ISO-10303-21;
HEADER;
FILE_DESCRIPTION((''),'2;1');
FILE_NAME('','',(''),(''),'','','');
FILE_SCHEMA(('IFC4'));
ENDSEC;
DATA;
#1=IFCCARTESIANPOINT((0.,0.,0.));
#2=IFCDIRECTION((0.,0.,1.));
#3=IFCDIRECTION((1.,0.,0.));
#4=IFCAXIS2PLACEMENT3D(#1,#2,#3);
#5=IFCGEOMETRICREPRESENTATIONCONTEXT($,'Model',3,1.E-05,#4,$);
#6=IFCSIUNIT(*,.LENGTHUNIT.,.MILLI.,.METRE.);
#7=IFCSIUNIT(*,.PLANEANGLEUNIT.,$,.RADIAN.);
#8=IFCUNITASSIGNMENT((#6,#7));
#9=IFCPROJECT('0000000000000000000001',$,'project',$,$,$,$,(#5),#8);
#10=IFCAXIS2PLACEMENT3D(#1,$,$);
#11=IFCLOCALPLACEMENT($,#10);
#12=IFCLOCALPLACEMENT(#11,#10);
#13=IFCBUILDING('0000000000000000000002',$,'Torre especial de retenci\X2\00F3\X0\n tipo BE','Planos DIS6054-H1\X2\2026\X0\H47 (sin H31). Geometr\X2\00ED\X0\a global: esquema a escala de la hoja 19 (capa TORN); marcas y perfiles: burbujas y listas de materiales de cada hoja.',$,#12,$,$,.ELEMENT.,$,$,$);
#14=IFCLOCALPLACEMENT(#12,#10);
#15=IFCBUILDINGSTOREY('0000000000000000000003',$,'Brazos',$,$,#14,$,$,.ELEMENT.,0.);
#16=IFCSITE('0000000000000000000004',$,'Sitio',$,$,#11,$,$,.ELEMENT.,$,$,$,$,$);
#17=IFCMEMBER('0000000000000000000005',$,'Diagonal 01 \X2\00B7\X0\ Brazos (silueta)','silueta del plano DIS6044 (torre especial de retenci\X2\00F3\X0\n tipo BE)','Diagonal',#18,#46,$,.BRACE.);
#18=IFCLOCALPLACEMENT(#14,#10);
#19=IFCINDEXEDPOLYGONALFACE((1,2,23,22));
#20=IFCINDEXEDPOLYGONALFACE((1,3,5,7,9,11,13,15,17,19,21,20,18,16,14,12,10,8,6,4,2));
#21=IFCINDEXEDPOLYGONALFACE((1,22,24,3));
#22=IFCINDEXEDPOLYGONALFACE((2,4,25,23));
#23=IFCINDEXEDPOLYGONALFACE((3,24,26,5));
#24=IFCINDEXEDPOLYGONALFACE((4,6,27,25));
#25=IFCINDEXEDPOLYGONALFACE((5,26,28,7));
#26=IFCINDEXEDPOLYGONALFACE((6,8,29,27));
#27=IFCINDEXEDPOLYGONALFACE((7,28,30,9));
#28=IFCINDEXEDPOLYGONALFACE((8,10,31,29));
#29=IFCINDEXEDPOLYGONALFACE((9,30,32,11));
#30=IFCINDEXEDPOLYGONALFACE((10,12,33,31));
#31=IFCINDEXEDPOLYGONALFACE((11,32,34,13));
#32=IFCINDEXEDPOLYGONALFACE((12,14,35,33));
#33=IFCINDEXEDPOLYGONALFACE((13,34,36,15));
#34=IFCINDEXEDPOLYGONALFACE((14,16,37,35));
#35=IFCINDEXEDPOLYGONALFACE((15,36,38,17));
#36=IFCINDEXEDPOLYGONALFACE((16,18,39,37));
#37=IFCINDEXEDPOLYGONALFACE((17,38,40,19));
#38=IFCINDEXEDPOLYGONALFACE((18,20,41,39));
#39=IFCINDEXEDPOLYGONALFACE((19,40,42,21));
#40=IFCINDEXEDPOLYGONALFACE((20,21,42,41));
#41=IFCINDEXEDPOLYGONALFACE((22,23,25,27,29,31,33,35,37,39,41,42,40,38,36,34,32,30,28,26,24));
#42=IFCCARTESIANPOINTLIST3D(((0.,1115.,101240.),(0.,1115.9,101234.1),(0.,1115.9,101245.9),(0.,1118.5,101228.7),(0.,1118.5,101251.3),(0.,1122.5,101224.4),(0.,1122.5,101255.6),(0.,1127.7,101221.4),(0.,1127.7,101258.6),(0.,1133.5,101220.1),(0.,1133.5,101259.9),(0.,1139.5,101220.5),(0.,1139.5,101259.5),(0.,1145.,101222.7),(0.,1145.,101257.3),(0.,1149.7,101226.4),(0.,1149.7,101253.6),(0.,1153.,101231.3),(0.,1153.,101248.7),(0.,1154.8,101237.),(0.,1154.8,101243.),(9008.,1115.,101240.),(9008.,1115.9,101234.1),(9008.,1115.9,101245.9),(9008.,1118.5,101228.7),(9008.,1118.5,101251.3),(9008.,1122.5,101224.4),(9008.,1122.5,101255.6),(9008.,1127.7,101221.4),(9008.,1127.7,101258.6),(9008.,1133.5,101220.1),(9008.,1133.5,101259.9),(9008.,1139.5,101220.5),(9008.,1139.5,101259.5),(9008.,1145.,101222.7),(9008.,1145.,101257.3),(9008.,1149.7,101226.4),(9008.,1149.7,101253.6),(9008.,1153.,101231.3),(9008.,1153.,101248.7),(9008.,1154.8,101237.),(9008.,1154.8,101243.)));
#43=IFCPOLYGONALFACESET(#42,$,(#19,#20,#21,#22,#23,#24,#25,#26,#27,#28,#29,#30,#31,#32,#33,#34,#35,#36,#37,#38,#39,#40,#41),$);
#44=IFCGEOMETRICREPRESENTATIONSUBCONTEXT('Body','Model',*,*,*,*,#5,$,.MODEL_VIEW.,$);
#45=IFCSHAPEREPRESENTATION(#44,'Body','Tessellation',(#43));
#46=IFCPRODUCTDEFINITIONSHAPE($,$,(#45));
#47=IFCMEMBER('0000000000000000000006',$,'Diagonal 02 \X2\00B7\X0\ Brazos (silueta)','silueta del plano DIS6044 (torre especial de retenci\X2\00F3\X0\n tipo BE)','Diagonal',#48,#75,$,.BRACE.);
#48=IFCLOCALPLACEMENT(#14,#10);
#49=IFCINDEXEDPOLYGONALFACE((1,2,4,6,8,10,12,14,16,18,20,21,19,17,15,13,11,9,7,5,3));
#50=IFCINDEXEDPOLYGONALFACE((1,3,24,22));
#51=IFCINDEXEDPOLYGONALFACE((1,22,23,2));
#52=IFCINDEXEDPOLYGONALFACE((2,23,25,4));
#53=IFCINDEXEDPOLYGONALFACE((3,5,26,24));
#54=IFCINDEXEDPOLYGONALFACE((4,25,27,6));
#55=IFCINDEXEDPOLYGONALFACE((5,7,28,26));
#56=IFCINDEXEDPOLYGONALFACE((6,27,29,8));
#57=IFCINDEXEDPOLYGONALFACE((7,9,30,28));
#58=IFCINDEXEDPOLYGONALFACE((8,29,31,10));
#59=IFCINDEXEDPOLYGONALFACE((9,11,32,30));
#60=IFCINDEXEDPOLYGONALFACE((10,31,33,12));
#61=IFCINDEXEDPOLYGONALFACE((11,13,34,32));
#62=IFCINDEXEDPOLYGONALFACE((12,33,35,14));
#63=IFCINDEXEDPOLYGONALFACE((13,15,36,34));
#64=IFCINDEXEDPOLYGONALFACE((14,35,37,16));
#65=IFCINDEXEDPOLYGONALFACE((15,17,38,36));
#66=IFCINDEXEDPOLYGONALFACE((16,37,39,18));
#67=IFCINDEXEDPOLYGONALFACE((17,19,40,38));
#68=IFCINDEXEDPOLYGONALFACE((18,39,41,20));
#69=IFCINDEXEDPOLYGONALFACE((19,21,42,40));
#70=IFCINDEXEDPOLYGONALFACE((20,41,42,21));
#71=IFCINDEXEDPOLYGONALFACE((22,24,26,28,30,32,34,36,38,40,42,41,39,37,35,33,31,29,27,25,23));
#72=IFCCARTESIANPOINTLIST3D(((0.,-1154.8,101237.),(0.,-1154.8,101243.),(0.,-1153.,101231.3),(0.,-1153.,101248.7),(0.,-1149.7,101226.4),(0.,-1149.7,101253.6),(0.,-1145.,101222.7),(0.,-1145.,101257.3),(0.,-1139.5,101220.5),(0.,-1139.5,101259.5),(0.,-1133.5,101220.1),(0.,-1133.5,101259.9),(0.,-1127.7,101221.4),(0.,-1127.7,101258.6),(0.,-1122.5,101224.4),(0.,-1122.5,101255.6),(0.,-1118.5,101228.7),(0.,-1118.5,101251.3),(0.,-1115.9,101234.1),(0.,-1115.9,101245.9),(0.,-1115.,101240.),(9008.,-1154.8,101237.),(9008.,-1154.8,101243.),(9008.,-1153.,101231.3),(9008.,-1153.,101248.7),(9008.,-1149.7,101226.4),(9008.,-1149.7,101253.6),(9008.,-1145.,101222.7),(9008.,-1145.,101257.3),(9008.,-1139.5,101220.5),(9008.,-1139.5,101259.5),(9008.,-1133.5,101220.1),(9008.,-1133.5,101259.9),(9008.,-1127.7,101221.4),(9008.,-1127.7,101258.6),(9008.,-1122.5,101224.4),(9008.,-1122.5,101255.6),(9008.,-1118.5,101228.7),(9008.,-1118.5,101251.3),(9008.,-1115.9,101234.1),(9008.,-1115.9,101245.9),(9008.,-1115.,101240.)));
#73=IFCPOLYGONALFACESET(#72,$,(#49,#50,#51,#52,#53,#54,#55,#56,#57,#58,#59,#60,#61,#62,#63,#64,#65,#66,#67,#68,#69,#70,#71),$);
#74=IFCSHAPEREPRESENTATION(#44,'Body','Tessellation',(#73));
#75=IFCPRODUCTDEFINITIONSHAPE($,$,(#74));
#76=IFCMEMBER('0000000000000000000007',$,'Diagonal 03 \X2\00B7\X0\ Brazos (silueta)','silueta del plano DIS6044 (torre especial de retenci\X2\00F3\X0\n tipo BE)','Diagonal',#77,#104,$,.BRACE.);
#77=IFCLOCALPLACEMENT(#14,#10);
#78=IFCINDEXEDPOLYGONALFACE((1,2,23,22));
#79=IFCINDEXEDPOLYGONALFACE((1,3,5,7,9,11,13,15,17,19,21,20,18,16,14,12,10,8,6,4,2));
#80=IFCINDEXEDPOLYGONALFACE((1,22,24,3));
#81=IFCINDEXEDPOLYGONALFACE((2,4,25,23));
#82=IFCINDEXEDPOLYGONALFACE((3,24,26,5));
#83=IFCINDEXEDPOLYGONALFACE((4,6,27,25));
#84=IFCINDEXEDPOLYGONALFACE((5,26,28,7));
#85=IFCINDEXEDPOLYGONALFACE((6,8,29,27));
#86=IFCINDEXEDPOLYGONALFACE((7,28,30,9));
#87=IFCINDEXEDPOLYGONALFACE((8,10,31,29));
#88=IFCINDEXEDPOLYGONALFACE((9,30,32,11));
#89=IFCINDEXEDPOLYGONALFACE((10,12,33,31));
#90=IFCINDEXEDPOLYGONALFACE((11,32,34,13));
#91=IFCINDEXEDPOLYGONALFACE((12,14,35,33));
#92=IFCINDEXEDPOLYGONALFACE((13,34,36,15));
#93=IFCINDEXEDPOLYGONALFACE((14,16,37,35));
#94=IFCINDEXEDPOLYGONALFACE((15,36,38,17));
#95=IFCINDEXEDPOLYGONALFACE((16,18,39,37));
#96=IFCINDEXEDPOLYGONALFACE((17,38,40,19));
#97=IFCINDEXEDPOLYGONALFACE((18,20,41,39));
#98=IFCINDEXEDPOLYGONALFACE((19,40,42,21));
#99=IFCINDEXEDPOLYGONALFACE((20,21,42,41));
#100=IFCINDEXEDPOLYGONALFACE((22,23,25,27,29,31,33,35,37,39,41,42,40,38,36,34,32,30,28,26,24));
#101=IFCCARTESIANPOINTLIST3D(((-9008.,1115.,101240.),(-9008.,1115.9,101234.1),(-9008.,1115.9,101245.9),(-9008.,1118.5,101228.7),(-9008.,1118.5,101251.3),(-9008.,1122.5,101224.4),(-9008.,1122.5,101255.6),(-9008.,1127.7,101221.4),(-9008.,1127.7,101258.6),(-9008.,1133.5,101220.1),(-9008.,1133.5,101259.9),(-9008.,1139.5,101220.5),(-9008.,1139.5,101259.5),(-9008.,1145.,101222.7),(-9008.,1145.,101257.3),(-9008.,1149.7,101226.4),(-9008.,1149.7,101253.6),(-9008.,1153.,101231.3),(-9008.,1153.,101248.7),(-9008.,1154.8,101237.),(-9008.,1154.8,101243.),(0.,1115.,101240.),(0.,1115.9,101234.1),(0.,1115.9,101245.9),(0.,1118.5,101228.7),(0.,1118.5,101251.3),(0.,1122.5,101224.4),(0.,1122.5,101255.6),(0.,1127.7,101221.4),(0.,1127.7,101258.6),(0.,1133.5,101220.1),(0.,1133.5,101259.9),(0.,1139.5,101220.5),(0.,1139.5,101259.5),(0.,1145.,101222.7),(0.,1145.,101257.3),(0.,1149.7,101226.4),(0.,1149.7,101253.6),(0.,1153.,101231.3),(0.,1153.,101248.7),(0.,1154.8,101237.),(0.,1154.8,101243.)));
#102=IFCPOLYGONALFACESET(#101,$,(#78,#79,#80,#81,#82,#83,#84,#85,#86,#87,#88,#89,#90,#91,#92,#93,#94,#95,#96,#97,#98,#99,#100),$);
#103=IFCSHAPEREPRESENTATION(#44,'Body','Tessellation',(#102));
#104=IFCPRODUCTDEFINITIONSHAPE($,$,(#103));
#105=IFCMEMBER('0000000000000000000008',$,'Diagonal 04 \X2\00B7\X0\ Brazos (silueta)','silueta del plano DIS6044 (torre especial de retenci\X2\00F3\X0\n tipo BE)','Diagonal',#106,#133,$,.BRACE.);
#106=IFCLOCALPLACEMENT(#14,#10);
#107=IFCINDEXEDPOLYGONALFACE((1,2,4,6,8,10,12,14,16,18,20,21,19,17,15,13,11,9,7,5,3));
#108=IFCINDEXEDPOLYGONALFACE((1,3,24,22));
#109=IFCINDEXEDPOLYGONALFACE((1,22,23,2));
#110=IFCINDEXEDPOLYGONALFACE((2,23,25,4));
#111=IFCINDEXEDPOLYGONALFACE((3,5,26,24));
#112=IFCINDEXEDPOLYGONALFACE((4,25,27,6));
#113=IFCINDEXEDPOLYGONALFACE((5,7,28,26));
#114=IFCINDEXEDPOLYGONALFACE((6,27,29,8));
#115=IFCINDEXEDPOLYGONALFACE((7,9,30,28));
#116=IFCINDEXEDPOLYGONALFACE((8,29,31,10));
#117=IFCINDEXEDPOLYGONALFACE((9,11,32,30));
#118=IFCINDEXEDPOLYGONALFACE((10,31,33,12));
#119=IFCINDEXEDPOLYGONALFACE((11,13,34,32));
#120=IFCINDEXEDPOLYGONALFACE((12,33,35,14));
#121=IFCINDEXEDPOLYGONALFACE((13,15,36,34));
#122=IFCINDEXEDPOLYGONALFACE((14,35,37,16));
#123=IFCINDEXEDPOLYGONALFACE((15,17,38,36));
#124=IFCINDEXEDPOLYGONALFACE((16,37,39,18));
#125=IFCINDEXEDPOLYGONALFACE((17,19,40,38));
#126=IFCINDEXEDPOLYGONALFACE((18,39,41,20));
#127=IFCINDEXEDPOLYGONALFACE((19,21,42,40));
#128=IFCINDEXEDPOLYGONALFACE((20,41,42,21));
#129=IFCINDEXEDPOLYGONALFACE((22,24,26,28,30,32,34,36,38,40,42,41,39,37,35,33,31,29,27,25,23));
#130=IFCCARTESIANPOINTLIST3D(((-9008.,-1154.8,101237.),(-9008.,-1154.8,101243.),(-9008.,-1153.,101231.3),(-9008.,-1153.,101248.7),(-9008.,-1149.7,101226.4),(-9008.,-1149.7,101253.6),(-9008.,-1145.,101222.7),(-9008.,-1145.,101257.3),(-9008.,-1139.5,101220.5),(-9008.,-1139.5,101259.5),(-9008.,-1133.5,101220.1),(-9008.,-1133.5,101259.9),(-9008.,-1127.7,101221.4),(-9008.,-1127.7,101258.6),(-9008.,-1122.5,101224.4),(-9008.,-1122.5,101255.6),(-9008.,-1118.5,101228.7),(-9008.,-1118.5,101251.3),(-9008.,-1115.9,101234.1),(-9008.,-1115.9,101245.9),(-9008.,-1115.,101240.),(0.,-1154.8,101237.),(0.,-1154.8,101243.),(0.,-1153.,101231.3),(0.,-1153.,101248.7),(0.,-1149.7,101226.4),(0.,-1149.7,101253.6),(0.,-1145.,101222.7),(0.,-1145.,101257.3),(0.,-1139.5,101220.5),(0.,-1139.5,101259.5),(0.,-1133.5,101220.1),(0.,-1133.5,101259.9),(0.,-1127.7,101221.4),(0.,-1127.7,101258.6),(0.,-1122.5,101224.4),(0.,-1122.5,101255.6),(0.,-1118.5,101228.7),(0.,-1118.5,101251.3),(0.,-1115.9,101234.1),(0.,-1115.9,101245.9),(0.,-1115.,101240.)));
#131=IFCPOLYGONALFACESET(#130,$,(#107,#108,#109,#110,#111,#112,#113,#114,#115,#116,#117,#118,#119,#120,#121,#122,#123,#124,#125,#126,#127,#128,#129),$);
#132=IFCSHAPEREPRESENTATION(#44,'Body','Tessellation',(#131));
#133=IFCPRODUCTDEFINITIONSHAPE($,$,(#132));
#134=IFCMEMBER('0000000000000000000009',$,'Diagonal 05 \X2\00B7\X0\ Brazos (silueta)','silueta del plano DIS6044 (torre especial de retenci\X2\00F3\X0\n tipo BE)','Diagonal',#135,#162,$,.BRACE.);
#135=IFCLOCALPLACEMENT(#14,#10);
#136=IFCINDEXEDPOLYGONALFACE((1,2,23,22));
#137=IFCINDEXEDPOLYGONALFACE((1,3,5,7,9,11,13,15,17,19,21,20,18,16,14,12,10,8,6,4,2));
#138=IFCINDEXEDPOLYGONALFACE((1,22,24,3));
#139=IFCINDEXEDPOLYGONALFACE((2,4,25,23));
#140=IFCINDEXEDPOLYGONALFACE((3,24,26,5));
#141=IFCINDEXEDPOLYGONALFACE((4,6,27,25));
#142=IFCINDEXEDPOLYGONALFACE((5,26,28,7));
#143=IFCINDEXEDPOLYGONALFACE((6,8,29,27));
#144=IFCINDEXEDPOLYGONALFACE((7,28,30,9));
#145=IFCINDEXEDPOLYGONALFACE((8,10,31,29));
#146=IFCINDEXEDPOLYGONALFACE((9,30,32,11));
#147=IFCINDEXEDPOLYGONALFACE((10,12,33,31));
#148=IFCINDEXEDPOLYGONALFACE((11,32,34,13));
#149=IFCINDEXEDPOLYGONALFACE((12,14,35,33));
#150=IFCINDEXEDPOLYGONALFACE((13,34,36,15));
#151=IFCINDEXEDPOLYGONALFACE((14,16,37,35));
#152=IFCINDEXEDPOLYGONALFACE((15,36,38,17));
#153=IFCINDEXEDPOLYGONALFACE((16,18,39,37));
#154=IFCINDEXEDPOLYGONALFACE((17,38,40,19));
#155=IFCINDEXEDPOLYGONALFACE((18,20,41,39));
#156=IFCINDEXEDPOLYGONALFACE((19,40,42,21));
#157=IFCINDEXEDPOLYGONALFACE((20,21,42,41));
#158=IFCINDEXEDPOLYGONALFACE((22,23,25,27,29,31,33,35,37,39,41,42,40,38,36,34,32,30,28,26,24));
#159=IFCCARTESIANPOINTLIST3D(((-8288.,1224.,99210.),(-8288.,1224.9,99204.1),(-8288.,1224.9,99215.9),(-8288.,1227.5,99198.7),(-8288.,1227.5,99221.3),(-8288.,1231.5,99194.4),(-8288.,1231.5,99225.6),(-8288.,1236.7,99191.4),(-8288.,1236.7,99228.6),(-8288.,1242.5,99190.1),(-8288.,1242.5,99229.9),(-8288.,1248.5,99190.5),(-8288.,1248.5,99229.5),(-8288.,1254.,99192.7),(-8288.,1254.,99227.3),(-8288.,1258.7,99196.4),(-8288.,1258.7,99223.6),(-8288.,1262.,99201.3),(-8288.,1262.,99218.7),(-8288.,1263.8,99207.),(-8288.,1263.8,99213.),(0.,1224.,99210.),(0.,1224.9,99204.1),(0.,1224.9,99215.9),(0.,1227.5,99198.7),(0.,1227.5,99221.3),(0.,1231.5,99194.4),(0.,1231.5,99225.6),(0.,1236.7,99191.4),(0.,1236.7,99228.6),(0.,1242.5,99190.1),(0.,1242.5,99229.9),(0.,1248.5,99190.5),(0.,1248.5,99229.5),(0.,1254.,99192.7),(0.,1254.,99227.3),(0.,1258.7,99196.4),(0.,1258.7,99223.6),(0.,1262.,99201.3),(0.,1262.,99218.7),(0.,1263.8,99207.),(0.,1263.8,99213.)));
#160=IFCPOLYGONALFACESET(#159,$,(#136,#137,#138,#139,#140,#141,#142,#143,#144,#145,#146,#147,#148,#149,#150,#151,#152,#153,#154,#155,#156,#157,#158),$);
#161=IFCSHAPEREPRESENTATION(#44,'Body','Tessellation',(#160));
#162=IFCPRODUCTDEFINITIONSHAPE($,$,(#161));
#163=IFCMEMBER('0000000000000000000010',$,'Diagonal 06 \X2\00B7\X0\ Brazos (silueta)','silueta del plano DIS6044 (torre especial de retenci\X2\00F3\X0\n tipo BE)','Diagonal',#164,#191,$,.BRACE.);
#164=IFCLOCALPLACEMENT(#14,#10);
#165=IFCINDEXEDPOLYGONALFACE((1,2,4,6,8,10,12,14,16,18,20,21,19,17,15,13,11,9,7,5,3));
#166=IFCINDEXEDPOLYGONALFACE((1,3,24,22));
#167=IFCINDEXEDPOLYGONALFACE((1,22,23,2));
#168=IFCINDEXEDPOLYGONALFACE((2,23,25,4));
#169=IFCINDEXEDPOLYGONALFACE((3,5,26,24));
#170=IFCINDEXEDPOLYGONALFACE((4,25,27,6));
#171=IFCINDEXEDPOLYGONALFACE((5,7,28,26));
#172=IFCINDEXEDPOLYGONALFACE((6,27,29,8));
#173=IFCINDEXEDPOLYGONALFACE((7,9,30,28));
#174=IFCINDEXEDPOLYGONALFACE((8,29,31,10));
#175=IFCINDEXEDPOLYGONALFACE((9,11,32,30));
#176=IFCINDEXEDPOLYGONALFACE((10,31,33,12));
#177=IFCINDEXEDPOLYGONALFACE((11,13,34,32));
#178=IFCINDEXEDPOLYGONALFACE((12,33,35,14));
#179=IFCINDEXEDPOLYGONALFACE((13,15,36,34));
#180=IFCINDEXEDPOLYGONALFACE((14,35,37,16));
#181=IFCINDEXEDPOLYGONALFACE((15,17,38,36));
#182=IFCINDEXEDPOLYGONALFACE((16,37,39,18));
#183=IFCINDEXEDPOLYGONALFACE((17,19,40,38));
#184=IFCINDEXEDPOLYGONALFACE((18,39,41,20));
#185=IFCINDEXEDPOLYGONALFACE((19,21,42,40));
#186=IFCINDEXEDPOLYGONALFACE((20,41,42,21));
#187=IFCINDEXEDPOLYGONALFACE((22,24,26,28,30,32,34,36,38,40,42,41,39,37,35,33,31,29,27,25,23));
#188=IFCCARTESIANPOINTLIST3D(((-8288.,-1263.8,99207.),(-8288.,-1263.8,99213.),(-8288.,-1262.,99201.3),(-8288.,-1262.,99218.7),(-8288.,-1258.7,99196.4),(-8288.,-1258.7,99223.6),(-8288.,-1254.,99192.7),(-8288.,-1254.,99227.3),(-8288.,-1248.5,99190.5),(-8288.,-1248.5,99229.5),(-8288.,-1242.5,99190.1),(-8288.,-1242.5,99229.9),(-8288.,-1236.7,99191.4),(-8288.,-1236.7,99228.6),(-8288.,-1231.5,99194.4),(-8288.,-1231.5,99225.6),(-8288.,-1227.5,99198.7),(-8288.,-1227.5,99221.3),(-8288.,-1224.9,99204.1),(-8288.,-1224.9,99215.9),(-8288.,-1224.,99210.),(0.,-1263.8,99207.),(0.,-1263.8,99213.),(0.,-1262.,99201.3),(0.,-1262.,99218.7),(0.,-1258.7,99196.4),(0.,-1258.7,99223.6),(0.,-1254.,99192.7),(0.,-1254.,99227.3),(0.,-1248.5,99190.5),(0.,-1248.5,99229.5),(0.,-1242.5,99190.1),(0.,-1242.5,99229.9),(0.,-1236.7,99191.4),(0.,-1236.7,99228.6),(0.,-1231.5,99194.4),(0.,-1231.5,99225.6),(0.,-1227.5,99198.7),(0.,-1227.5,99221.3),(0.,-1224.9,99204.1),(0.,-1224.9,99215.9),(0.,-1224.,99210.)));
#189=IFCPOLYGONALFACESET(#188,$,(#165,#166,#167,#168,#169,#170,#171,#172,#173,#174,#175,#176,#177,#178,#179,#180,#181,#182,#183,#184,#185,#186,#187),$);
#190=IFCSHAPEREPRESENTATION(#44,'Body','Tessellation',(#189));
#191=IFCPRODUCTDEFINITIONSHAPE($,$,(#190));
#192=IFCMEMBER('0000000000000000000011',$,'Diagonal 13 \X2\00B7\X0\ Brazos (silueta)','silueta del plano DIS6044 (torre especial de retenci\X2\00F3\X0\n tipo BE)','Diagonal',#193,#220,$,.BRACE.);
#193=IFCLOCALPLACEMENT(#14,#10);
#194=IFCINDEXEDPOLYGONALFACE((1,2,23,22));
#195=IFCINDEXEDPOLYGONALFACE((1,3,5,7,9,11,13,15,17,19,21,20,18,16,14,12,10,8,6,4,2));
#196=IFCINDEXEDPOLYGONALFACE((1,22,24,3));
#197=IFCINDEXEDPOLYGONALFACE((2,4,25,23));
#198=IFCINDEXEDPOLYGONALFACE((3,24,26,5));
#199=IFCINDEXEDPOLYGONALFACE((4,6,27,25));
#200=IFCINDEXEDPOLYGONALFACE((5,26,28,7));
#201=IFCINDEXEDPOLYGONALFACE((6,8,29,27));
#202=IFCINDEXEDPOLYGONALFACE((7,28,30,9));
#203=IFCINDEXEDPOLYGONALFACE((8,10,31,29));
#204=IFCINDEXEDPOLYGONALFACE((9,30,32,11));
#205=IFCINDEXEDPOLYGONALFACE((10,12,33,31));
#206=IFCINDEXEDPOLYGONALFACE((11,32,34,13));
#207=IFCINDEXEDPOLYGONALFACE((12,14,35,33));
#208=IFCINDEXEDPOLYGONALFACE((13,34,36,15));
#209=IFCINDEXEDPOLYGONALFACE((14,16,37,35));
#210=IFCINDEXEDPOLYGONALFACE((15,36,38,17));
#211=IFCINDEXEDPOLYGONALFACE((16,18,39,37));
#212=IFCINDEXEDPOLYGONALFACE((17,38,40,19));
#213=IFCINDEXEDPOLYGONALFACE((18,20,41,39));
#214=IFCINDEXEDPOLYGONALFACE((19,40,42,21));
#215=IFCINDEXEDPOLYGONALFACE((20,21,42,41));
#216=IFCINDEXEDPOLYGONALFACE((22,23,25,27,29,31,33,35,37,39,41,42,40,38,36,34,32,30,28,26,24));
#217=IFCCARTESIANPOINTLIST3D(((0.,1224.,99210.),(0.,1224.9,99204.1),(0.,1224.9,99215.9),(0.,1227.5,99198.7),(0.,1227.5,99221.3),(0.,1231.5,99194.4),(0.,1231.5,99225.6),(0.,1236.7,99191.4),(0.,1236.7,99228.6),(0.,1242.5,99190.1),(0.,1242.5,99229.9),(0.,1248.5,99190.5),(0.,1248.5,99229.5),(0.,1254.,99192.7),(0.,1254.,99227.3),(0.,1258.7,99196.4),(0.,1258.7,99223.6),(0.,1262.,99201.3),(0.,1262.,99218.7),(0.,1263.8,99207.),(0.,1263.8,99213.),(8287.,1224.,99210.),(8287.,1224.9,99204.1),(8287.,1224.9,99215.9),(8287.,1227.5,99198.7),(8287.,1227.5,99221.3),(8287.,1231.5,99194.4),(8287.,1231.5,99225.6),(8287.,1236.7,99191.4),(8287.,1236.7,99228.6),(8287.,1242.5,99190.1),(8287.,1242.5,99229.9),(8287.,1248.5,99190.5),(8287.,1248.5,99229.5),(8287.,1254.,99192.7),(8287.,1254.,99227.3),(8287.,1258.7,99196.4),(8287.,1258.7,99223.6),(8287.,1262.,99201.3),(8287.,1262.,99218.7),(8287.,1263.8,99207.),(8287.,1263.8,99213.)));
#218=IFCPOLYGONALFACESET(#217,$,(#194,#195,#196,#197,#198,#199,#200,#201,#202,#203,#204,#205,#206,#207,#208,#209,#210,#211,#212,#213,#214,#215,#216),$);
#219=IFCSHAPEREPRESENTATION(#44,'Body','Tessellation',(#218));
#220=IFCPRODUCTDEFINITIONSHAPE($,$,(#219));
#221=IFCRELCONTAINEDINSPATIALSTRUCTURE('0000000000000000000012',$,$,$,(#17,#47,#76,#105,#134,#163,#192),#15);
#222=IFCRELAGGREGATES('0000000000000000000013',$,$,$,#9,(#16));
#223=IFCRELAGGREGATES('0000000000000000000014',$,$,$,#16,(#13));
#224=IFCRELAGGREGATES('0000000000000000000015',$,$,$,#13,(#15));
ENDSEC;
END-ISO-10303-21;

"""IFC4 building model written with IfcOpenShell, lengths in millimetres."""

from ifc_helpers import new_model, si_unit, frame, origin, origin_with_axes, place, context, subcontext, project, spatial, circle, extrude, element, save


model = new_model("IFC4")

# Units and contexts
model_context = context("Model", 3, precision=1e-05, world=origin_with_axes())
body_context = subcontext(model_context, "Body", "Model", "MODEL_VIEW")
ifc_project = project(units=[si_unit("LENGTHUNIT", "METRE", prefix="MILLI"), si_unit("PLANEANGLEUNIT", "RADIAN")], contexts=[model_context])

# Site, building, storey
site_placement = place(None, origin())
site = spatial("IfcSite", under=ifc_project, at=site_placement, Name="Sitio", CompositionType="ELEMENT")
building_placement = place(site_placement, origin())
building = spatial("IfcBuilding", under=site, at=building_placement, Name="Torre especial de retención tipo BE", Description="Planos DIS6054-H1…H47 (sin H31). Geometría global: esquema a escala de la hoja 19 (capa TORN); marcas y perfiles: burbujas y listas de materiales de cada hoja.", CompositionType="ELEMENT")
storey_placement = place(building_placement, origin())
storey = spatial("IfcBuildingStorey", under=building, at=storey_placement, Name="Brazos", CompositionType="ELEMENT", Elevation=0.0)

# Members
for number, where, z_axis, x_axis, name in (
    (1, (0.0, 1135.0, 101240.0), (1.0, 0.0, 0.0), (0.0, -1.0, 0.0), "Diagonal 01 · Brazos (silueta)"),
    (2, (0.0, -1135.0, 101240.0), (1.0, 0.0, 0.0), (0.0, 1.0, 0.0), "Diagonal 02 · Brazos (silueta)"),
    (3, (0.0, 1135.0, 101240.0), (-1.0, 0.0, 0.0), (0.0, -1.0, 0.0), "Diagonal 03 · Brazos (silueta)"),
    (4, (0.0, -1135.0, 101240.0), (-1.0, 0.0, 0.0), (0.0, 1.0, 0.0), "Diagonal 04 · Brazos (silueta)"),
):
    element("IfcMember", number, at=place(storey_placement, frame(where, z_axis=z_axis, x_axis=x_axis)), inside=storey, Name=name, Description="silueta del plano DIS6044 (torre especial de retención tipo BE)", ObjectType="Diagonal", PredefinedType="BRACE", context=body_context, shape_type="SweptSolid", body=[
        extrude(circle(Radius=20.0), None, (0.0, 0.0, 1.0), 9008.0),
    ])
for number, where, z_axis, x_axis, name in (
    (5, (0.0, 1244.0, 99210.0), (-1.0, 0.0, 0.0), (0.0, -1.0, 0.0), "Diagonal 05 · Brazos (silueta)"),
    (6, (0.0, -1244.0, 99210.0), (-1.0, 0.0, 0.0), (0.0, 1.0, 0.0), "Diagonal 06 · Brazos (silueta)"),
):
    element("IfcMember", number, at=place(storey_placement, frame(where, z_axis=z_axis, x_axis=x_axis)), inside=storey, Name=name, Description="silueta del plano DIS6044 (torre especial de retención tipo BE)", ObjectType="Diagonal", PredefinedType="BRACE", context=body_context, shape_type="SweptSolid", body=[
        extrude(circle(Radius=20.0), None, (0.0, 0.0, 1.0), 8288.0),
    ])
for number, where, z_axis, x_axis, name in (
    (7, (0.0, 1244.0, 99210.0), (1.0, 0.0, 0.0), (0.0, -1.0, 0.0), "Diagonal 13 · Brazos (silueta)"),
):
    element("IfcMember", number, at=place(storey_placement, frame(where, z_axis=z_axis, x_axis=x_axis)), inside=storey, Name=name, Description="silueta del plano DIS6044 (torre especial de retención tipo BE)", ObjectType="Diagonal", PredefinedType="BRACE", context=body_context, shape_type="SweptSolid", body=[
        extrude(circle(Radius=20.0), None, (0.0, 0.0, 1.0), 8287.0),
    ])

save(model, "model.ifc")
